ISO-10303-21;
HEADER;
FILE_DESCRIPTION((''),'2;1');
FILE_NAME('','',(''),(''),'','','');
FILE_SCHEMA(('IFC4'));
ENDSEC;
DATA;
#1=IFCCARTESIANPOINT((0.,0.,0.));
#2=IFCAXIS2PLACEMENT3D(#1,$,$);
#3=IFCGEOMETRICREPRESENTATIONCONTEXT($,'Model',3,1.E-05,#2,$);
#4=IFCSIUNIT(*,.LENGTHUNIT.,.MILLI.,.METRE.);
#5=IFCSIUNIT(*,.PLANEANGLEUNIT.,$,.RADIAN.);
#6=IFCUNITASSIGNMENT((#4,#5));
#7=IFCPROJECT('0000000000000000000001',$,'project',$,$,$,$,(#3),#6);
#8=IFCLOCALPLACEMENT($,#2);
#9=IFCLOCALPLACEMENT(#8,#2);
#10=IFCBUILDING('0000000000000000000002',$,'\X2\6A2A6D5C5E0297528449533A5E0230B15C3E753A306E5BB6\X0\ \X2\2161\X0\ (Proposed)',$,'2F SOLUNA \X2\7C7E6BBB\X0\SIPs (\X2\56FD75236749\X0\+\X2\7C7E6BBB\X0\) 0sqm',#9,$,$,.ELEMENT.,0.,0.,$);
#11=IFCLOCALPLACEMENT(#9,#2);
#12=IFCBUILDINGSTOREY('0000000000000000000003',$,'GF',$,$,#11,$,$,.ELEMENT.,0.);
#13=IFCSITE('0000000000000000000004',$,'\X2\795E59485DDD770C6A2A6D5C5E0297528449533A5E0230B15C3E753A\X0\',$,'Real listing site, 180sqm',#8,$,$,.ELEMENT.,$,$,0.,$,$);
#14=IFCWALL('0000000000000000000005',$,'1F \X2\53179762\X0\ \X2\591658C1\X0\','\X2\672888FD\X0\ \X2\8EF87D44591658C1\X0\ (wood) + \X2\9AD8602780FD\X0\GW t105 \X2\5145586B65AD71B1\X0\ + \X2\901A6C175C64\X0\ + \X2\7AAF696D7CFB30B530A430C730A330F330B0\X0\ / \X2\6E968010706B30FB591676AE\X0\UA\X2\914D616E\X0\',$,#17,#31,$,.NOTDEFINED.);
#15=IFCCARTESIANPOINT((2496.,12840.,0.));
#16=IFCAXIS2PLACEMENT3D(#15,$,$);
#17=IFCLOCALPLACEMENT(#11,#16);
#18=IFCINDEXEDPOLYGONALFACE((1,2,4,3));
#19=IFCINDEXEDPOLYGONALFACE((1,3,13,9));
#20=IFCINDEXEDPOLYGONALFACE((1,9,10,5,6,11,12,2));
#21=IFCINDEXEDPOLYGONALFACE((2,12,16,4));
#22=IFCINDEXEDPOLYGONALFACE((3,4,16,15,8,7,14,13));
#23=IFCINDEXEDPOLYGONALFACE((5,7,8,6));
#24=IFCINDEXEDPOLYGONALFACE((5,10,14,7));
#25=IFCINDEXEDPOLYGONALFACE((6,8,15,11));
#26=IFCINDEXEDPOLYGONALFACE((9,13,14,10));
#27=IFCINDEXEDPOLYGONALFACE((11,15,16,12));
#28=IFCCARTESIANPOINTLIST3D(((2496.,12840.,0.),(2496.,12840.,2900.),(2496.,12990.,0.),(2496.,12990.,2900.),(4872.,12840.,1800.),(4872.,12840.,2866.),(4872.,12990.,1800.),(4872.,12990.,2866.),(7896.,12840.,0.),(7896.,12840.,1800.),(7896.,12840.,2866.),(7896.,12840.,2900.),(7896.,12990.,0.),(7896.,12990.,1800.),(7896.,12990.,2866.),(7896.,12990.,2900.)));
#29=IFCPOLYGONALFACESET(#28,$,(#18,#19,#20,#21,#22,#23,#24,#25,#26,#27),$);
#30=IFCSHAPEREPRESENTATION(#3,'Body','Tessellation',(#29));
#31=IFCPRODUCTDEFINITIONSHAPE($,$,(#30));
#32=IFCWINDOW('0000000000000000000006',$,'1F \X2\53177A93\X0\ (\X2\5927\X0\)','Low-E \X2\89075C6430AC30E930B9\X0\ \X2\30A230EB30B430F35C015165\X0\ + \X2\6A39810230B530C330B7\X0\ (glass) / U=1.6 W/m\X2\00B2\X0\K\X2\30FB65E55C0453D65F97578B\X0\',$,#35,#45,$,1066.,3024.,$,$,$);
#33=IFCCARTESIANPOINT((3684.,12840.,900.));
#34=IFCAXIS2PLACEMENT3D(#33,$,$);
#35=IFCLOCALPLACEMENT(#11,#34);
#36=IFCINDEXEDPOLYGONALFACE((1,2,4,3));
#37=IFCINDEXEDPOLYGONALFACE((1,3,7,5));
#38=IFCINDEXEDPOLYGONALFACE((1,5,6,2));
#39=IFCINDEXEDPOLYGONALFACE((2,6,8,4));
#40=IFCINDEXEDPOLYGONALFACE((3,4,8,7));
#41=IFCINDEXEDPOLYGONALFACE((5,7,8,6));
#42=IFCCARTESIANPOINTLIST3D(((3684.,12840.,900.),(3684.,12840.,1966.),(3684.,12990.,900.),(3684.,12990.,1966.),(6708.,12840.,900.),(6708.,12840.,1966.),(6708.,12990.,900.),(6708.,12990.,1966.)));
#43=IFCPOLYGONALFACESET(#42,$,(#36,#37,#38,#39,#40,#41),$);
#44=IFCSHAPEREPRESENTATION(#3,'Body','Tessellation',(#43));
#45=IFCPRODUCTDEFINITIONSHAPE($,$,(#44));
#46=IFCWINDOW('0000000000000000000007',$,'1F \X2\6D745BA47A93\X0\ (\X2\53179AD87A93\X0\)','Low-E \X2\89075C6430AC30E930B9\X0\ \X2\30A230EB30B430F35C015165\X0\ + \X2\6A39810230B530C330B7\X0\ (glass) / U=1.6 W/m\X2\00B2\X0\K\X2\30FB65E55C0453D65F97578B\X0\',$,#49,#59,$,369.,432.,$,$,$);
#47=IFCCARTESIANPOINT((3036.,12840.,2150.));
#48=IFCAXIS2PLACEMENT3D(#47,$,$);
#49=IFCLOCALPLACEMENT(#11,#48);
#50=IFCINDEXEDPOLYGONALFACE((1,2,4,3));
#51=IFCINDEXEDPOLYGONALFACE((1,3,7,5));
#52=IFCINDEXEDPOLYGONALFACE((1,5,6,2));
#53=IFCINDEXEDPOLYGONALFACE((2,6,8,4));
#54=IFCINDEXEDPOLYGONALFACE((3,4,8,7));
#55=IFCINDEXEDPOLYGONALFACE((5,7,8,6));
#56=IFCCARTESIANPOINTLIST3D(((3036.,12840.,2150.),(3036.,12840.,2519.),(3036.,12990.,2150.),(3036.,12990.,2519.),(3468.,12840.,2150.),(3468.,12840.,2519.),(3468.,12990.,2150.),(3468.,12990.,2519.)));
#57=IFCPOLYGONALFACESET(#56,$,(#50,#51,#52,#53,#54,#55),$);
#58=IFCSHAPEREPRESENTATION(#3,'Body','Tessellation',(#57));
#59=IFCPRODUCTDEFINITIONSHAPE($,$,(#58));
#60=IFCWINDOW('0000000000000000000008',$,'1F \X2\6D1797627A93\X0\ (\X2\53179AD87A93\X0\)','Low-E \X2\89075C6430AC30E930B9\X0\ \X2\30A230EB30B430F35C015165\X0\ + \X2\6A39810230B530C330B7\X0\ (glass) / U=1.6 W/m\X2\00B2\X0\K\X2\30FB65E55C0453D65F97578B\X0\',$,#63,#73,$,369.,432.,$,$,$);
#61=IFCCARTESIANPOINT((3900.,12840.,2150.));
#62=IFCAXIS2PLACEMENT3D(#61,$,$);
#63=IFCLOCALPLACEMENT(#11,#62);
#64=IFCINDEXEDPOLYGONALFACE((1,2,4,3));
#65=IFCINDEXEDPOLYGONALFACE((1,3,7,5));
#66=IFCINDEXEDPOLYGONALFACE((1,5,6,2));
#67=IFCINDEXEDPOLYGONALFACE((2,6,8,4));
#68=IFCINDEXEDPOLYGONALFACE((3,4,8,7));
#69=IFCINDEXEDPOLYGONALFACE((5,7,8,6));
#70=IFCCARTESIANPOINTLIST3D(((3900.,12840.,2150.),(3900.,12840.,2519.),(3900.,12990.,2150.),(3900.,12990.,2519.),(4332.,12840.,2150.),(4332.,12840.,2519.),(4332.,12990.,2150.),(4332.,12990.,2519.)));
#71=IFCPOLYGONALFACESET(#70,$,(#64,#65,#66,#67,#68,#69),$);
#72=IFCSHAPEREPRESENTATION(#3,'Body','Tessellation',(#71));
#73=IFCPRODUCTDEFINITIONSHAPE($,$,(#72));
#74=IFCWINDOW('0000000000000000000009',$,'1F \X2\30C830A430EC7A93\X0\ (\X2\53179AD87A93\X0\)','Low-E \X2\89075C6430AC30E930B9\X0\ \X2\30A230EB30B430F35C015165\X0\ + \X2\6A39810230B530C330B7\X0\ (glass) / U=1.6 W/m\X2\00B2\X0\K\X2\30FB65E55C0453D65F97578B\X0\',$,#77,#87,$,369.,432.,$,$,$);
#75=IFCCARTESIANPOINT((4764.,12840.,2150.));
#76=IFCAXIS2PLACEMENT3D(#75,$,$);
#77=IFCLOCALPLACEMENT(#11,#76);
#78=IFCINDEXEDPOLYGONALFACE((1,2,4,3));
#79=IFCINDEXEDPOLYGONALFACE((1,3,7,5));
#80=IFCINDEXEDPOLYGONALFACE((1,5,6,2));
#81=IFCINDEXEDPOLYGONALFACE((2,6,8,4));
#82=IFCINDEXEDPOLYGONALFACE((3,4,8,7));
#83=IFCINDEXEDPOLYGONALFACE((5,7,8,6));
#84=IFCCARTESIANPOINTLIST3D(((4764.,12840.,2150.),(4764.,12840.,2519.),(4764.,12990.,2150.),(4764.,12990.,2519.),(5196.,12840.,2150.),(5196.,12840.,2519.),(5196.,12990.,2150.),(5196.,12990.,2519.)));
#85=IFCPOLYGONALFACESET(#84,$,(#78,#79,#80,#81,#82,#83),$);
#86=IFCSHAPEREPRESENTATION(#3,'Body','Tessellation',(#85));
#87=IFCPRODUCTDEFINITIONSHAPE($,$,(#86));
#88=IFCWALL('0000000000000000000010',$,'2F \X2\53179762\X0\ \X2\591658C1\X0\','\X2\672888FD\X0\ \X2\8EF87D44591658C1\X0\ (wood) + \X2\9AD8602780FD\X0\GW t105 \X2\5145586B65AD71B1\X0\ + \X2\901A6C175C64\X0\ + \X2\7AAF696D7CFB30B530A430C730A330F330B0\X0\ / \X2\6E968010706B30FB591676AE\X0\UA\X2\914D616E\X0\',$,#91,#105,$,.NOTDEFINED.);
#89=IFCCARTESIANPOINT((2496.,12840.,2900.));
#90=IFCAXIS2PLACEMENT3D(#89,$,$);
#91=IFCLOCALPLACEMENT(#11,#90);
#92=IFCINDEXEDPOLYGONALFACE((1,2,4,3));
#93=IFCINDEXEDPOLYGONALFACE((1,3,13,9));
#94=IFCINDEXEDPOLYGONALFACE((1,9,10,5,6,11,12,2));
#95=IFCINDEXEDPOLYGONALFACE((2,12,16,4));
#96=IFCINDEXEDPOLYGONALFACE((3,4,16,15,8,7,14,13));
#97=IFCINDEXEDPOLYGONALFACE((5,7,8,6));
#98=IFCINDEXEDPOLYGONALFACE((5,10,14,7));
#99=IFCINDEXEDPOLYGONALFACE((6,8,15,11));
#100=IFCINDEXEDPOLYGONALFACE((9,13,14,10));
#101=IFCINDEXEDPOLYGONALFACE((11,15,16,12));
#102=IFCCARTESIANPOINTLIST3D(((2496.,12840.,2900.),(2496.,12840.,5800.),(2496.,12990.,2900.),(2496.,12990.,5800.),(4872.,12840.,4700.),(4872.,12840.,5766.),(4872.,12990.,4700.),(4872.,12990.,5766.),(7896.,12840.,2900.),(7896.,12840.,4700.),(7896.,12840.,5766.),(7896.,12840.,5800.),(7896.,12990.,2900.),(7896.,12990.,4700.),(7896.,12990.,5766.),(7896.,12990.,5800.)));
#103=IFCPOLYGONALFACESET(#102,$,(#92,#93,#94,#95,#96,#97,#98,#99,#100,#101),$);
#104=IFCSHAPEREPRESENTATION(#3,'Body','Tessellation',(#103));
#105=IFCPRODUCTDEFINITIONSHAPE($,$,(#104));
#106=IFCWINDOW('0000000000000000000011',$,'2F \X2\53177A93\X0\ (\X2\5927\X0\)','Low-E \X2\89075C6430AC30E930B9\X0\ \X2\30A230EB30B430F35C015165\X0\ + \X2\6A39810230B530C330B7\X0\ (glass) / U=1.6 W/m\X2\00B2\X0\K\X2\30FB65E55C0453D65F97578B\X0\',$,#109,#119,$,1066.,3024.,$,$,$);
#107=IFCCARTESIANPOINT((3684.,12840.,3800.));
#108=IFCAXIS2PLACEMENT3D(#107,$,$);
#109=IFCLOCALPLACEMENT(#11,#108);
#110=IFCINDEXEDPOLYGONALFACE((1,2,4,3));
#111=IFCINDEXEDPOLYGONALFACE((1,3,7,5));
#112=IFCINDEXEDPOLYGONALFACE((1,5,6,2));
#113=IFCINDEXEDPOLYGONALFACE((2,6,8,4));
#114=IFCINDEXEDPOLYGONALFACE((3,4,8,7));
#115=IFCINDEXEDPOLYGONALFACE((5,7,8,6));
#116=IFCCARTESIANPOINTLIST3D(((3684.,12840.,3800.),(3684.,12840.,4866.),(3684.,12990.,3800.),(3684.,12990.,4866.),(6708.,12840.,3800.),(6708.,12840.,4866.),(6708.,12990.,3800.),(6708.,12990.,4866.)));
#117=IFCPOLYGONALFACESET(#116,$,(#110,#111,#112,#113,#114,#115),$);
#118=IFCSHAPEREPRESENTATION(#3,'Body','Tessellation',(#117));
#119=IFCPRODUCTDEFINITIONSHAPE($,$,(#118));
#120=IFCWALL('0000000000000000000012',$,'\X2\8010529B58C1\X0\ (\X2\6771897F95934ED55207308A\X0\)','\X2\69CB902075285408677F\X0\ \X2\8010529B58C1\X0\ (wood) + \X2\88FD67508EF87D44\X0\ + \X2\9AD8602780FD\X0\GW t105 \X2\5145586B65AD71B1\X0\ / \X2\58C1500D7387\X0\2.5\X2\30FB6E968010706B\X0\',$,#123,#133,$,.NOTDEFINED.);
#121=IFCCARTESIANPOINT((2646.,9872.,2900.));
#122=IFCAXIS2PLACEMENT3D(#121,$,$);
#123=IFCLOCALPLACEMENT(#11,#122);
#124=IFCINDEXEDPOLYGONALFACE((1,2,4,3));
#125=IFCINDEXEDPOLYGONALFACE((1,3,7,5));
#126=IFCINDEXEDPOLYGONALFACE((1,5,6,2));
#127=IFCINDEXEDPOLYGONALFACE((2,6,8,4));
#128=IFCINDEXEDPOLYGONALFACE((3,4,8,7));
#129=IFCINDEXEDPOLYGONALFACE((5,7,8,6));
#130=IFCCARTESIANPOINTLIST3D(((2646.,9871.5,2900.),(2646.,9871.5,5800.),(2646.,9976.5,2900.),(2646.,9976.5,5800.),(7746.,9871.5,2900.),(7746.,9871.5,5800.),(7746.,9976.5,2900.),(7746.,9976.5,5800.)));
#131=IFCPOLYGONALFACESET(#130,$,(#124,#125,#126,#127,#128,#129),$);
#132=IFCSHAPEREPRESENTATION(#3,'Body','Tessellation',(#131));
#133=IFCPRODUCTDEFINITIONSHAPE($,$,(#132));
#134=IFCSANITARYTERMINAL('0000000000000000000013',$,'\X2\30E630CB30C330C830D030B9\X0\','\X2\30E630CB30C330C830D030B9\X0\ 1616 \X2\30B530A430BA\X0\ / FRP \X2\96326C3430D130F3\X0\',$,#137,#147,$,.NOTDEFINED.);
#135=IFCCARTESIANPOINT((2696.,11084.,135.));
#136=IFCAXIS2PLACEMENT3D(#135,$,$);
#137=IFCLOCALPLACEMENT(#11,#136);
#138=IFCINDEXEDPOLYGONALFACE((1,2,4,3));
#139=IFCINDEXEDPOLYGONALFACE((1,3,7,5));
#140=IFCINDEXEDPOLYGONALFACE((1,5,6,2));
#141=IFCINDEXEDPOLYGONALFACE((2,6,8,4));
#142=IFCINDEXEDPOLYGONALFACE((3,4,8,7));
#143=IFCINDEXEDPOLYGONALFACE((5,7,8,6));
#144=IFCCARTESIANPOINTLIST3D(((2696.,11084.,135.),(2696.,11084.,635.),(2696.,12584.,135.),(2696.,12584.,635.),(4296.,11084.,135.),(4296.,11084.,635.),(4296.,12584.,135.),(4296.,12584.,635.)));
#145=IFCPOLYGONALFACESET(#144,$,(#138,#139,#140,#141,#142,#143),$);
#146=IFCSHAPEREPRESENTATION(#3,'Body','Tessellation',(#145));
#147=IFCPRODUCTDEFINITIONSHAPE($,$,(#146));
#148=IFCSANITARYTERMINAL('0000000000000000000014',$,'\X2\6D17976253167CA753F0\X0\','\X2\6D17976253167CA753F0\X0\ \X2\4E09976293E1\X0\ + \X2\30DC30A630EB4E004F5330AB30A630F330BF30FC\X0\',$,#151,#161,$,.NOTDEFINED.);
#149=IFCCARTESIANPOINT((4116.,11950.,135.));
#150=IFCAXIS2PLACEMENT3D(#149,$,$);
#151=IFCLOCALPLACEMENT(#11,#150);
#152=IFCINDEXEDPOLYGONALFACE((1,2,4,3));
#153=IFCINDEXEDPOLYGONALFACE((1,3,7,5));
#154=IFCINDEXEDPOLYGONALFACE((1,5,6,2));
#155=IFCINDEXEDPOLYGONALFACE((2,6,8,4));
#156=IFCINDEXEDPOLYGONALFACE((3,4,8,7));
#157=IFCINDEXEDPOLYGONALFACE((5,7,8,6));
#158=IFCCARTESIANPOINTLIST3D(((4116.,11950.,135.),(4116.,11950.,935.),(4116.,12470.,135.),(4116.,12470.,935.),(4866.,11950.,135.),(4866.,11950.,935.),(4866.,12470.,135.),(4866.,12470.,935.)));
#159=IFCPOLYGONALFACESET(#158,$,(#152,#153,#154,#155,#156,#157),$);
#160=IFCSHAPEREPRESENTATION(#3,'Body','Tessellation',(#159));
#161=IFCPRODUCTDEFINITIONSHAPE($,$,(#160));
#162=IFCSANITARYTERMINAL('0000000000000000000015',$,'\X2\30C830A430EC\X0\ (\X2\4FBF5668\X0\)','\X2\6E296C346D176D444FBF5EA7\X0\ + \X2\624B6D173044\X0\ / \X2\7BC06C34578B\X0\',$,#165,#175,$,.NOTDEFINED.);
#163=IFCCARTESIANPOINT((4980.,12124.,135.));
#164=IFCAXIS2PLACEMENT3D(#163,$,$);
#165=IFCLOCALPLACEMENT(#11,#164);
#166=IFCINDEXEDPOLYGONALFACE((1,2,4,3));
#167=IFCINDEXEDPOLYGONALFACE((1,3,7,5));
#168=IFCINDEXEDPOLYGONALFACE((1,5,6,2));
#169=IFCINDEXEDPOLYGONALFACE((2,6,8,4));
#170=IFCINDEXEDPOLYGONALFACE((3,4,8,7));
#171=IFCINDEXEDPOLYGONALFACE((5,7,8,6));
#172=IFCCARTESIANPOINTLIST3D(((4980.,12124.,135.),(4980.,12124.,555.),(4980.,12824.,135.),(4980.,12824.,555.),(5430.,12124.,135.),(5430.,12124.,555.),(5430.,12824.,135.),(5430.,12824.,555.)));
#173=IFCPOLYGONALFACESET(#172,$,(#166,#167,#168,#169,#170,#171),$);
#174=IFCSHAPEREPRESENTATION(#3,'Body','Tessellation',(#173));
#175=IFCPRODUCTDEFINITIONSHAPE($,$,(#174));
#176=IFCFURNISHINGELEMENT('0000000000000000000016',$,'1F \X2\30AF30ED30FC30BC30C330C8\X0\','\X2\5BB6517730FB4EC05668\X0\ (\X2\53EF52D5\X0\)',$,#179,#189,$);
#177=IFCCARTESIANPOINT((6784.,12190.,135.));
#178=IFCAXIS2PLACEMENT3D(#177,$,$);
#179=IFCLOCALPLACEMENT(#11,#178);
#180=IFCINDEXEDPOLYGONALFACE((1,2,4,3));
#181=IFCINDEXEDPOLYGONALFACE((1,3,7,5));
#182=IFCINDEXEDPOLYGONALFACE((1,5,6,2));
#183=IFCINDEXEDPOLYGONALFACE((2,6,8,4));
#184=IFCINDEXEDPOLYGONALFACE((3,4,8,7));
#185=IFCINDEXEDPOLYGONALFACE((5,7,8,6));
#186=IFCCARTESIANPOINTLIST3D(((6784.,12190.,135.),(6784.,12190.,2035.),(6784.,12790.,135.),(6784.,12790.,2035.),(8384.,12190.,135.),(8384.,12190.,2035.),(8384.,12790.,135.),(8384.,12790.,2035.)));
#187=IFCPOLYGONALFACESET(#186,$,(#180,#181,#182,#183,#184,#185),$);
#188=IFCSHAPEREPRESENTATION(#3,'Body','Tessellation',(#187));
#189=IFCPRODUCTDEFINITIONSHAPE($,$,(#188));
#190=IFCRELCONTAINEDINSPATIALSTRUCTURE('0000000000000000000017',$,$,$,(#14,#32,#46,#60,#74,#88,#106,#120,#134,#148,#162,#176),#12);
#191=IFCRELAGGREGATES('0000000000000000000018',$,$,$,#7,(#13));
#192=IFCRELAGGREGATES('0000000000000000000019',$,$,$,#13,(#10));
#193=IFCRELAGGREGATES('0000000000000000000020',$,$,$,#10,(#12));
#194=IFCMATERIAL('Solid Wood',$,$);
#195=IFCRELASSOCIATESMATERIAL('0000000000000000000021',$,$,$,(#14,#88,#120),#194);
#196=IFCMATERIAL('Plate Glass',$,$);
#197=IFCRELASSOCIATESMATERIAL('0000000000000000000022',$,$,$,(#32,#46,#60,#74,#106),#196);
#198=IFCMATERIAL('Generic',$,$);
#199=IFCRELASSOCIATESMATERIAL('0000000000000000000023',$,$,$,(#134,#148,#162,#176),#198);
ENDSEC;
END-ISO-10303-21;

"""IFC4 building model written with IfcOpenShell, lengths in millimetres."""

from ifc_helpers import new_model, si_unit, frame, frame_2d, origin, place, context, project, spatial, rectangle, extrude, material, element, fill, save


model = new_model("IFC4")

# Units and contexts
model_context = context("Model", 3, precision=1e-05, world=origin())
ifc_project = project(units=[si_unit("LENGTHUNIT", "METRE", prefix="MILLI"), si_unit("PLANEANGLEUNIT", "RADIAN")], contexts=[model_context])

# Site, building, storey
site_placement = place(None, origin())
site = spatial("IfcSite", under=ifc_project, at=site_placement, Name="神奈川県横浜市青葉区市ケ尾町", ObjectType="Real listing site, 180sqm", CompositionType="ELEMENT", RefElevation=0.0)
building_placement = place(site_placement, origin())
building = spatial("IfcBuilding", under=site, at=building_placement, Name="横浜市青葉区市ケ尾町の家 Ⅱ (Proposed)", ObjectType="2F SOLUNA 籾殻SIPs (国産杉+籾殻) 0sqm", CompositionType="ELEMENT", ElevationOfRefHeight=0.0, ElevationOfTerrain=0.0)
storey_placement = place(building_placement, origin())
storey = spatial("IfcBuildingStorey", under=building, at=storey_placement, Name="GF", CompositionType="ELEMENT", Elevation=0.0)

# Wall, openings, windows
ifc_material_1 = material(Name="Solid Wood")
wall_1_placement = place(storey_placement, frame((2496.0, 12840.0, 0.0)))
wall_1 = element("IfcWall", 1, at=wall_1_placement, inside=storey, material=ifc_material_1, Name="1F 北面 外壁", Description="木製 軸組外壁 (wood) + 高性能GW t105 充填断熱 + 通気層 + 窯業系サイディング / 準耐火・外皮UA配慮", PredefinedType="NOTDEFINED", context=model_context, shape_type="SweptSolid", body=[
    extrude(rectangle(XDim=5400.0, YDim=150.0, at=frame_2d((2700.0, 75.0))), frame((2496.0, 12840.0, 0.0)), (0.0, 0.0, 1.0), 2900.0),
])
opening_1_placement = place(storey_placement, frame((3684.0, 12840.0, 900.0)))
opening_1 = element("IfcOpeningElement", 2, at=opening_1_placement, cuts=wall_1, PredefinedType="NOTDEFINED", context=model_context, shape_type="SweptSolid", body=[
    extrude(rectangle(XDim=3024.0, YDim=150.0, at=frame_2d((1512.0, 75.0))), frame((3684.0, 12840.0, 900.0)), (0.0, 0.0, 1.0), 1066.0),
])
opening_2_placement = place(storey_placement, frame((3036.0, 12840.0, 2150.0)))
opening_2 = element("IfcOpeningElement", 3, at=opening_2_placement, cuts=wall_1, PredefinedType="NOTDEFINED", context=model_context, shape_type="SweptSolid", body=[
    extrude(rectangle(XDim=432.0, YDim=150.0, at=frame_2d((216.0, 75.0))), frame((3036.0, 12840.0, 2150.0)), (0.0, 0.0, 1.0), 369.0),
])
opening_3_placement = place(storey_placement, frame((3900.0, 12840.0, 2150.0)))
opening_3 = element("IfcOpeningElement", 4, at=opening_3_placement, cuts=wall_1, PredefinedType="NOTDEFINED", context=model_context, shape_type="SweptSolid", body=[
    extrude(rectangle(XDim=432.0, YDim=150.0, at=frame_2d((216.0, 75.0))), frame((3900.0, 12840.0, 2150.0)), (0.0, 0.0, 1.0), 369.0),
])
opening_4_placement = place(storey_placement, frame((4764.0, 12840.0, 2150.0)))
opening_4 = element("IfcOpeningElement", 5, at=opening_4_placement, cuts=wall_1, PredefinedType="NOTDEFINED", context=model_context, shape_type="SweptSolid", body=[
    extrude(rectangle(XDim=432.0, YDim=150.0, at=frame_2d((216.0, 75.0))), frame((4764.0, 12840.0, 2150.0)), (0.0, 0.0, 1.0), 369.0),
])
ifc_material_2 = material(Name="Plate Glass")
window_1_placement = place(storey_placement, frame((3684.0, 12840.0, 900.0)))
window_1 = element("IfcWindow", 6, at=window_1_placement, inside=storey, material=ifc_material_2, Name="1F 北窓 (大)", Description="Low-E 複層ガラス アルゴン封入 + 樹脂サッシ (glass) / U=1.6 W/m²K・日射取得型", OverallHeight=1066.0, OverallWidth=3024.0, context=model_context, shape_type="SweptSolid", body=[
    extrude(rectangle(XDim=3024.0, YDim=150.0, at=frame_2d((1512.0, 75.0))), frame((3684.0, 12840.0, 900.0)), (0.0, 0.0, 1.0), 1066.0),
])
fill(opening_1, window_1)
window_2_placement = place(storey_placement, frame((3036.0, 12840.0, 2150.0)))
window_2 = element("IfcWindow", 7, at=window_2_placement, inside=storey, material=ifc_material_2, Name="1F 浴室窓 (北高窓)", Description="Low-E 複層ガラス アルゴン封入 + 樹脂サッシ (glass) / U=1.6 W/m²K・日射取得型", OverallHeight=369.0, OverallWidth=432.0, context=model_context, shape_type="SweptSolid", body=[
    extrude(rectangle(XDim=432.0, YDim=150.0, at=frame_2d((216.0, 75.0))), frame((3036.0, 12840.0, 2150.0)), (0.0, 0.0, 1.0), 369.0),
])
fill(opening_2, window_2)
window_3_placement = place(storey_placement, frame((3900.0, 12840.0, 2150.0)))
window_3 = element("IfcWindow", 8, at=window_3_placement, inside=storey, material=ifc_material_2, Name="1F 洗面窓 (北高窓)", Description="Low-E 複層ガラス アルゴン封入 + 樹脂サッシ (glass) / U=1.6 W/m²K・日射取得型", OverallHeight=369.0, OverallWidth=432.0, context=model_context, shape_type="SweptSolid", body=[
    extrude(rectangle(XDim=432.0, YDim=150.0, at=frame_2d((216.0, 75.0))), frame((3900.0, 12840.0, 2150.0)), (0.0, 0.0, 1.0), 369.0),
])
fill(opening_3, window_3)
window_4_placement = place(storey_placement, frame((4764.0, 12840.0, 2150.0)))
window_4 = element("IfcWindow", 9, at=window_4_placement, inside=storey, material=ifc_material_2, Name="1F トイレ窓 (北高窓)", Description="Low-E 複層ガラス アルゴン封入 + 樹脂サッシ (glass) / U=1.6 W/m²K・日射取得型", OverallHeight=369.0, OverallWidth=432.0, context=model_context, shape_type="SweptSolid", body=[
    extrude(rectangle(XDim=432.0, YDim=150.0, at=frame_2d((216.0, 75.0))), frame((4764.0, 12840.0, 2150.0)), (0.0, 0.0, 1.0), 369.0),
])
fill(opening_4, window_4)

# Wall, opening, window
wall_2_placement = place(storey_placement, frame((2496.0, 12840.0, 2900.0)))
wall_2 = element("IfcWall", 10, at=wall_2_placement, inside=storey, material=ifc_material_1, Name="2F 北面 外壁", Description="木製 軸組外壁 (wood) + 高性能GW t105 充填断熱 + 通気層 + 窯業系サイディング / 準耐火・外皮UA配慮", PredefinedType="NOTDEFINED", context=model_context, shape_type="SweptSolid", body=[
    extrude(rectangle(XDim=5400.0, YDim=150.0, at=frame_2d((2700.0, 75.0))), frame((2496.0, 12840.0, 2900.0)), (0.0, 0.0, 1.0), 2900.0),
])
opening_5_placement = place(storey_placement, frame((3684.0, 12840.0, 3800.0)))
opening_5 = element("IfcOpeningElement", 11, at=opening_5_placement, cuts=wall_2, PredefinedType="NOTDEFINED", context=model_context, shape_type="SweptSolid", body=[
    extrude(rectangle(XDim=3024.0, YDim=150.0, at=frame_2d((1512.0, 75.0))), frame((3684.0, 12840.0, 3800.0)), (0.0, 0.0, 1.0), 1066.0),
])
window_5_placement = place(storey_placement, frame((3684.0, 12840.0, 3800.0)))
window_5 = element("IfcWindow", 12, at=window_5_placement, inside=storey, material=ifc_material_2, Name="2F 北窓 (大)", Description="Low-E 複層ガラス アルゴン封入 + 樹脂サッシ (glass) / U=1.6 W/m²K・日射取得型", OverallHeight=1066.0, OverallWidth=3024.0, context=model_context, shape_type="SweptSolid", body=[
    extrude(rectangle(XDim=3024.0, YDim=150.0, at=frame_2d((1512.0, 75.0))), frame((3684.0, 12840.0, 3800.0)), (0.0, 0.0, 1.0), 1066.0),
])
fill(opening_5, window_5)

# Wall
wall_3_placement = place(storey_placement, frame((2646.0, 9872.0, 2900.0)))
element("IfcWall", 13, at=wall_3_placement, inside=storey, material=ifc_material_1, Name="耐力壁 (東西間仕切り)", Description="構造用合板 耐力壁 (wood) + 製材軸組 + 高性能GW t105 充填断熱 / 壁倍率2.5・準耐火", PredefinedType="NOTDEFINED", context=model_context, shape_type="SweptSolid", body=[
    extrude(rectangle(XDim=5100.0, YDim=105.0, at=frame_2d((2550.0, 52.0))), frame((2646.0, 9872.0, 2900.0)), (0.0, 0.0, 1.0), 2900.0),
])

# Sanitary terminals
ifc_material_3 = material(Name="Generic")
sanitary_terminal_1_placement = place(storey_placement, frame((2696.0, 11084.0, 135.0)))
element("IfcSanitaryTerminal", 14, at=sanitary_terminal_1_placement, inside=storey, material=ifc_material_3, Name="ユニットバス", Description="ユニットバス 1616 サイズ / FRP 防水パン", PredefinedType="NOTDEFINED", context=model_context, shape_type="SweptSolid", body=[
    extrude(rectangle(XDim=1600.0, YDim=1500.0, at=frame_2d((800.0, 750.0))), frame((2696.0, 11084.0, 135.0)), (0.0, 0.0, 1.0), 500.0),
])
sanitary_terminal_2_placement = place(storey_placement, frame((4116.0, 11950.0, 135.0)))
element("IfcSanitaryTerminal", 15, at=sanitary_terminal_2_placement, inside=storey, material=ifc_material_3, Name="洗面化粧台", Description="洗面化粧台 三面鏡 + ボウル一体カウンター", PredefinedType="NOTDEFINED", context=model_context, shape_type="SweptSolid", body=[
    extrude(rectangle(XDim=750.0, YDim=520.0, at=frame_2d((375.0, 260.0))), frame((4116.0, 11950.0, 135.0)), (0.0, 0.0, 1.0), 800.0),
])
sanitary_terminal_3_placement = place(storey_placement, frame((4980.0, 12124.0, 135.0)))
element("IfcSanitaryTerminal", 16, at=sanitary_terminal_3_placement, inside=storey, material=ifc_material_3, Name="トイレ (便器)", Description="温水洗浄便座 + 手洗い / 節水型", PredefinedType="NOTDEFINED", context=model_context, shape_type="SweptSolid", body=[
    extrude(rectangle(XDim=450.0, YDim=700.0, at=frame_2d((225.0, 350.0))), frame((4980.0, 12124.0, 135.0)), (0.0, 0.0, 1.0), 420.0),
])

# Furnishing element
furnishing_1_placement = place(storey_placement, frame((6784.0, 12190.0, 135.0)))
element("IfcFurnishingElement", 17, at=furnishing_1_placement, inside=storey, material=ifc_material_3, Name="1F クローゼット", Description="家具・什器 (可動)", context=model_context, shape_type="SweptSolid", body=[
    extrude(rectangle(XDim=1600.0, YDim=600.0, at=frame_2d((800.0, 300.0))), frame((6784.0, 12190.0, 135.0)), (0.0, 0.0, 1.0), 1900.0),
])

save(model, "model.ifc")
